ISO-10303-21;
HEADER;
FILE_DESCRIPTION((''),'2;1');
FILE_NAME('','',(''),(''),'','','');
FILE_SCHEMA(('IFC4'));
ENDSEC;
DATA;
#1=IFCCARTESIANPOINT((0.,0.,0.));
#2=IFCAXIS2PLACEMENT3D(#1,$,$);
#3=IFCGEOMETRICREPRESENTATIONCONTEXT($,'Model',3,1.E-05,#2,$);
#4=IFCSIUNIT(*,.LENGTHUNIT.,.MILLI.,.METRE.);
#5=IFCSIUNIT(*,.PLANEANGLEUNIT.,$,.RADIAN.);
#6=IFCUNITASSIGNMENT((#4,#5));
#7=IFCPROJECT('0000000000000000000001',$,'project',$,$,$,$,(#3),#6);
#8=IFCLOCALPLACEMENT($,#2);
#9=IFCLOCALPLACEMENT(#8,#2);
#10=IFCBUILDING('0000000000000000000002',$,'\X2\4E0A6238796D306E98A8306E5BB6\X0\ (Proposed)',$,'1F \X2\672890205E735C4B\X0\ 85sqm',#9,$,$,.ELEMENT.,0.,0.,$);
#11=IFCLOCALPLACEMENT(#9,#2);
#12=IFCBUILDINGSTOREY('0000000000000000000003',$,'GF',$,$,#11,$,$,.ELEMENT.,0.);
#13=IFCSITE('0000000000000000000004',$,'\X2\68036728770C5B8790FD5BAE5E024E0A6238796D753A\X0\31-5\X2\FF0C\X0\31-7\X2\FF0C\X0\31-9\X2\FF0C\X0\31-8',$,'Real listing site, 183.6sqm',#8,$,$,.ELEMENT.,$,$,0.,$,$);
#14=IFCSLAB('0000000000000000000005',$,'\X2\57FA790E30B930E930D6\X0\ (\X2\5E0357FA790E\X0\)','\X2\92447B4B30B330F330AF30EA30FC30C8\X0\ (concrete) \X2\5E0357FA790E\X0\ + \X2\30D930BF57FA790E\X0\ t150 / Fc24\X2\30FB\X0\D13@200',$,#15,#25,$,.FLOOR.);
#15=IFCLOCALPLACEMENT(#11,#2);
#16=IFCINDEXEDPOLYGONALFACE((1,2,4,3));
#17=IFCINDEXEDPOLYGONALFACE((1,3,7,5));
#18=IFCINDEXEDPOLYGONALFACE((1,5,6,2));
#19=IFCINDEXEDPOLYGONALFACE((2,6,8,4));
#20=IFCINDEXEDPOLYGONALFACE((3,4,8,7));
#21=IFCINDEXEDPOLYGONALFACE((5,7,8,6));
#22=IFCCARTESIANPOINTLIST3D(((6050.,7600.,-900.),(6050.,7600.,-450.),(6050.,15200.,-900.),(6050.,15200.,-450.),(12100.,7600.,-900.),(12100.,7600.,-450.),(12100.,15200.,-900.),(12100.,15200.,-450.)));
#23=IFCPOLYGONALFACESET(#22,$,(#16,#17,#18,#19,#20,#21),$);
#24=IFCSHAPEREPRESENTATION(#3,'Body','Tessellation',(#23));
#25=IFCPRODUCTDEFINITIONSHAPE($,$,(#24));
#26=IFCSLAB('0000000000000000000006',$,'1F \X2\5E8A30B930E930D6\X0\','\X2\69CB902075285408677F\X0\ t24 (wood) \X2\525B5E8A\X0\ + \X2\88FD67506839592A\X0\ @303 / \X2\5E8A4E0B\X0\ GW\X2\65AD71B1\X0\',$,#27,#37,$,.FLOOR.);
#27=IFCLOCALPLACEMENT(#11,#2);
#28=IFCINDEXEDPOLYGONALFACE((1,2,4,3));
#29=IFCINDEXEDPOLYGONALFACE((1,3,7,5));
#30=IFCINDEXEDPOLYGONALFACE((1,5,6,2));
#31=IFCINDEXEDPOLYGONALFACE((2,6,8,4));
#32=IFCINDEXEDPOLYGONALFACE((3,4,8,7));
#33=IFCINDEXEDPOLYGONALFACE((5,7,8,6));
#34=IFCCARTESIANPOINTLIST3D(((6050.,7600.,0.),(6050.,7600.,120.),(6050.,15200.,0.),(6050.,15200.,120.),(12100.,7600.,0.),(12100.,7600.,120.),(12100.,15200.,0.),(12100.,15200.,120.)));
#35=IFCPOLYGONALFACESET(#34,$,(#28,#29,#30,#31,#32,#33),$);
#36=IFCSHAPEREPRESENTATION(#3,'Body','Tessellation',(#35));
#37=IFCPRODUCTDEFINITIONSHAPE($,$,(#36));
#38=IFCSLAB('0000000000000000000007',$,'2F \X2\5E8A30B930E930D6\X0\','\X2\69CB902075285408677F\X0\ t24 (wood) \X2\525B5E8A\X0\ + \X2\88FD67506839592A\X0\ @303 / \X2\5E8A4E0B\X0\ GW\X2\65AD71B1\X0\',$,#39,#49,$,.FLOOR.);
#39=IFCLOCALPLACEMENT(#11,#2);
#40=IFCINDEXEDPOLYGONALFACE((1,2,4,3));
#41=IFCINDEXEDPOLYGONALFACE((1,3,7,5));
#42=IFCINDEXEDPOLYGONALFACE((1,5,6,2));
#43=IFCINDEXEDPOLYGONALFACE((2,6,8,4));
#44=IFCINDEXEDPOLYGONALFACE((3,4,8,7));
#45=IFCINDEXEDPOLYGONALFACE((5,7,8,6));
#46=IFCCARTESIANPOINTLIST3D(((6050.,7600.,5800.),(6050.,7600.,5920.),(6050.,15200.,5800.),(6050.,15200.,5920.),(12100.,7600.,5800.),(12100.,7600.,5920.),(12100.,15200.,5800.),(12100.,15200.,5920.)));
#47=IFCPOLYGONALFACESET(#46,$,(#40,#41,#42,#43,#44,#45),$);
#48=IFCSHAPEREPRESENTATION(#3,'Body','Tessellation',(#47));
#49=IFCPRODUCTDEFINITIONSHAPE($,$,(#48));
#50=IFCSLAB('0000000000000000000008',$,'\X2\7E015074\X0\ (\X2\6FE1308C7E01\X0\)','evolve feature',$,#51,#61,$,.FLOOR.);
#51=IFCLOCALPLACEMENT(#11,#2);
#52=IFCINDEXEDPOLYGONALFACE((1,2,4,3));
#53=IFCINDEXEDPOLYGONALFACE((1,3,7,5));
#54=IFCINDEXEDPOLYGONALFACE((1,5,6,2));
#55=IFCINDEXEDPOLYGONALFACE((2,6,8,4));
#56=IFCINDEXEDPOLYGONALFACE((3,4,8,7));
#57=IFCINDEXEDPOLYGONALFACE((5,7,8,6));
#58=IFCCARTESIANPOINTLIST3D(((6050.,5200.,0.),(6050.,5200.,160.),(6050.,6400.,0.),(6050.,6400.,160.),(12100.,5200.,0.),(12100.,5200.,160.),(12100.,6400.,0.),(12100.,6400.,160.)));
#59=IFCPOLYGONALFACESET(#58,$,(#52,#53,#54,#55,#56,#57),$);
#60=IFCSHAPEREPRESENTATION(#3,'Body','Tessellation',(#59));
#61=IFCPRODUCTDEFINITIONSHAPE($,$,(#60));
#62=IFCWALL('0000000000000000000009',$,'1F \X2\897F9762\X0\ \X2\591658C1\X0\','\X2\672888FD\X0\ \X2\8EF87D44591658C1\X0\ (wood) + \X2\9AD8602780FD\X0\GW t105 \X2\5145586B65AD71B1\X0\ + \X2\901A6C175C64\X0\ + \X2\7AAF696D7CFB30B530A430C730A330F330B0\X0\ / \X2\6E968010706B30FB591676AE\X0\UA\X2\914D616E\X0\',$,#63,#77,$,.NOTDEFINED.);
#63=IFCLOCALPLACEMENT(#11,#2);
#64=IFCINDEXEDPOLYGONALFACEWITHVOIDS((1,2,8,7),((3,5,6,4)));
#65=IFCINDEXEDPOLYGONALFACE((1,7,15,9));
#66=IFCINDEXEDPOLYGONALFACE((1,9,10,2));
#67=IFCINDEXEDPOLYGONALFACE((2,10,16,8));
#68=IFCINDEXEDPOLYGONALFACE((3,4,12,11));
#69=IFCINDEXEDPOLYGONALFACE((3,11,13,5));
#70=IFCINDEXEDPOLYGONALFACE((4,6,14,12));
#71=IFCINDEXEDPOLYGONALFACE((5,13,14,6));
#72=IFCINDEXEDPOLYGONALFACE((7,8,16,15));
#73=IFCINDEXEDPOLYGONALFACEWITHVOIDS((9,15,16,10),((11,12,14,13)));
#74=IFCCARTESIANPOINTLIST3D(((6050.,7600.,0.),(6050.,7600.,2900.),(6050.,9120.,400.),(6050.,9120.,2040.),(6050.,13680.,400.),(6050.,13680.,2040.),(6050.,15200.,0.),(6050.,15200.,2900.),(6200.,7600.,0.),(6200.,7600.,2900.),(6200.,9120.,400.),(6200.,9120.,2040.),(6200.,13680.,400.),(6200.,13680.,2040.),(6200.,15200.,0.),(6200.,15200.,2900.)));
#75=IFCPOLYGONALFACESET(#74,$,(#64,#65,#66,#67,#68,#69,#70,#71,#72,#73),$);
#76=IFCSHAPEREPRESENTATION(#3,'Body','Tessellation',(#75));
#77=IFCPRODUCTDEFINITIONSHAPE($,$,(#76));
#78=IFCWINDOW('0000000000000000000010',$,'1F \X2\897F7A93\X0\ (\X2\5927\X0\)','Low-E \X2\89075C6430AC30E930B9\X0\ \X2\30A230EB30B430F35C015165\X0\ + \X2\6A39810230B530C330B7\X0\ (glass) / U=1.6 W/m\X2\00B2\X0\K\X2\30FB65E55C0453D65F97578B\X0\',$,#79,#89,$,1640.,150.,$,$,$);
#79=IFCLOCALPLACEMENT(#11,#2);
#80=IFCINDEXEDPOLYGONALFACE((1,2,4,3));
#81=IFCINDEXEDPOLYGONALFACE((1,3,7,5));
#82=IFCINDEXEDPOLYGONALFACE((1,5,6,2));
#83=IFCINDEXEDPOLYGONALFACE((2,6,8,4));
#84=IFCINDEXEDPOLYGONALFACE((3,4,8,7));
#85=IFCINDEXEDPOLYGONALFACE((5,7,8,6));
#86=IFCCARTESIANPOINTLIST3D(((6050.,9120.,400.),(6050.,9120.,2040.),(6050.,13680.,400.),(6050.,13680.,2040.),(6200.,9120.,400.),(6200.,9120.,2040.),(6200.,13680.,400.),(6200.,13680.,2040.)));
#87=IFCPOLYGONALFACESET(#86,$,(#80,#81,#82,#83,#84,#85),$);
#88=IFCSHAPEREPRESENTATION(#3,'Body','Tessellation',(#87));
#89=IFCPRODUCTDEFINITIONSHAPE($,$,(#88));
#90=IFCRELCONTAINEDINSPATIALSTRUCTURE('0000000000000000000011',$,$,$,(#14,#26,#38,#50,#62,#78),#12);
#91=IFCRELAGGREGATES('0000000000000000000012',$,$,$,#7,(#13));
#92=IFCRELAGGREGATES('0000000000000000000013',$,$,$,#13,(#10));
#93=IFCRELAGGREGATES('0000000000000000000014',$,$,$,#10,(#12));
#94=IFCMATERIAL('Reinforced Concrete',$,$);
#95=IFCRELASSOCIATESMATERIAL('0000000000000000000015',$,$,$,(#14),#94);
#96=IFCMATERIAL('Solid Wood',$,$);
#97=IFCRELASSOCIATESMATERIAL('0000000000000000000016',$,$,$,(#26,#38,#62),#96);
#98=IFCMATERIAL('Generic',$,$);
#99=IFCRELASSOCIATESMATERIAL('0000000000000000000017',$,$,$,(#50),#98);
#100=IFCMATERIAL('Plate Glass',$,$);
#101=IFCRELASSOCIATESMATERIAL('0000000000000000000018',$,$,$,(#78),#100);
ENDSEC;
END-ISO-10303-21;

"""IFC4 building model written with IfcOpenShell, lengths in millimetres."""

from ifc_helpers import new_model, si_unit, frame, frame_2d, origin, place, context, project, spatial, rectangle, extrude, material, element, fill, save


model = new_model("IFC4")

# Units and contexts
model_context = context("Model", 3, precision=1e-05, world=origin())
ifc_project = project(units=[si_unit("LENGTHUNIT", "METRE", prefix="MILLI"), si_unit("PLANEANGLEUNIT", "RADIAN")], contexts=[model_context])

# Site, building, storey
site_placement = place(None, origin())
site = spatial("IfcSite", under=ifc_project, at=site_placement, Name="栃木県宇都宮市上戸祭町31-5，31-7，31-9，31-8", ObjectType="Real listing site, 183.6sqm", CompositionType="ELEMENT", RefElevation=0.0)
building_placement = place(site_placement, origin())
building = spatial("IfcBuilding", under=site, at=building_placement, Name="上戸祭の風の家 (Proposed)", ObjectType="1F 木造平屋 85sqm", CompositionType="ELEMENT", ElevationOfRefHeight=0.0, ElevationOfTerrain=0.0)
storey_placement = place(building_placement, origin())
storey = spatial("IfcBuildingStorey", under=building, at=storey_placement, Name="GF", CompositionType="ELEMENT", Elevation=0.0)

# Slabs
ifc_material_1 = material(Name="Reinforced Concrete")
slab_1_placement = place(storey_placement, frame((3025.0, 3800.0, -450.0)))
element("IfcSlab", 1, at=slab_1_placement, inside=storey, material=ifc_material_1, Name="基礎スラブ (布基礎)", Description="鉄筋コンクリート (concrete) 布基礎 + ベタ基礎 t150 / Fc24・D13@200", PredefinedType="FLOOR", context=model_context, shape_type="SweptSolid", body=[
    extrude(rectangle(XDim=6050.0, YDim=7600.0, at=frame_2d((3025.0, 3800.0))), frame((3025.0, 3800.0, -450.0)), (0.0, 0.0, 1.0), 450.0),
])
ifc_material_2 = material(Name="Solid Wood")
slab_2_placement = place(storey_placement, frame((3025.0, 3800.0, 0.0)))
element("IfcSlab", 2, at=slab_2_placement, inside=storey, material=ifc_material_2, Name="1F 床スラブ", Description="構造用合板 t24 (wood) 剛床 + 製材根太 @303 / 床下 GW断熱", PredefinedType="FLOOR", context=model_context, shape_type="SweptSolid", body=[
    extrude(rectangle(XDim=6050.0, YDim=7600.0, at=frame_2d((3025.0, 3800.0))), frame((3025.0, 3800.0, 0.0)), (0.0, 0.0, 1.0), 120.0),
])
slab_3_placement = place(storey_placement, frame((3025.0, 3800.0, 2900.0)))
element("IfcSlab", 3, at=slab_3_placement, inside=storey, material=ifc_material_2, Name="2F 床スラブ", Description="構造用合板 t24 (wood) 剛床 + 製材根太 @303 / 床下 GW断熱", PredefinedType="FLOOR", context=model_context, shape_type="SweptSolid", body=[
    extrude(rectangle(XDim=6050.0, YDim=7600.0, at=frame_2d((3025.0, 3800.0))), frame((3025.0, 3800.0, 2900.0)), (0.0, 0.0, 1.0), 120.0),
])
ifc_material_3 = material(Name="Generic")
slab_4_placement = place(storey_placement, frame((3025.0, 2600.0, 0.0)))
element("IfcSlab", 4, at=slab_4_placement, inside=storey, material=ifc_material_3, Name="縁側 (濡れ縁)", Description="evolve feature", PredefinedType="FLOOR", context=model_context, shape_type="SweptSolid", body=[
    extrude(rectangle(XDim=6050.0, YDim=1200.0, at=frame_2d((3025.0, 600.0))), frame((3025.0, 2600.0, 0.0)), (0.0, 0.0, 1.0), 160.0),
])

# Shared definitions
ifc_material_4 = material(Name="Plate Glass")

# Wall, opening, window
wall_1_placement = place(storey_placement, frame((3025.0, 3800.0, 0.0)))
wall_1 = element("IfcWall", 5, at=wall_1_placement, inside=storey, material=ifc_material_2, Name="1F 西面 外壁", Description="木製 軸組外壁 (wood) + 高性能GW t105 充填断熱 + 通気層 + 窯業系サイディング / 準耐火・外皮UA配慮", PredefinedType="NOTDEFINED", context=model_context, shape_type="SweptSolid", body=[
    extrude(rectangle(XDim=150.0, YDim=7600.0, at=frame_2d((75.0, 3800.0))), frame((3025.0, 3800.0, 0.0)), (0.0, 0.0, 1.0), 2900.0),
])
opening_1_placement = place(storey_placement, frame((3025.0, 4560.0, 200.0)))
opening_1 = element("IfcOpeningElement", 6, at=opening_1_placement, cuts=wall_1, PredefinedType="NOTDEFINED", context=model_context, shape_type="SweptSolid", body=[
    extrude(rectangle(XDim=150.0, YDim=4560.0, at=frame_2d((75.0, 2280.0))), frame((3025.0, 4560.0, 200.0)), (0.0, 0.0, 1.0), 1640.0),
])
window_1_placement = place(storey_placement, frame((3025.0, 4560.0, 200.0)))
window_1 = element("IfcWindow", 7, at=window_1_placement, inside=storey, material=ifc_material_4, Name="1F 西窓 (大)", Description="Low-E 複層ガラス アルゴン封入 + 樹脂サッシ (glass) / U=1.6 W/m²K・日射取得型", OverallHeight=1640.0, OverallWidth=150.0, context=model_context, shape_type="SweptSolid", body=[
    extrude(rectangle(XDim=150.0, YDim=4560.0, at=frame_2d((75.0, 2280.0))), frame((3025.0, 4560.0, 200.0)), (0.0, 0.0, 1.0), 1640.0),
])
fill(opening_1, window_1)

save(model, "model.ifc")
